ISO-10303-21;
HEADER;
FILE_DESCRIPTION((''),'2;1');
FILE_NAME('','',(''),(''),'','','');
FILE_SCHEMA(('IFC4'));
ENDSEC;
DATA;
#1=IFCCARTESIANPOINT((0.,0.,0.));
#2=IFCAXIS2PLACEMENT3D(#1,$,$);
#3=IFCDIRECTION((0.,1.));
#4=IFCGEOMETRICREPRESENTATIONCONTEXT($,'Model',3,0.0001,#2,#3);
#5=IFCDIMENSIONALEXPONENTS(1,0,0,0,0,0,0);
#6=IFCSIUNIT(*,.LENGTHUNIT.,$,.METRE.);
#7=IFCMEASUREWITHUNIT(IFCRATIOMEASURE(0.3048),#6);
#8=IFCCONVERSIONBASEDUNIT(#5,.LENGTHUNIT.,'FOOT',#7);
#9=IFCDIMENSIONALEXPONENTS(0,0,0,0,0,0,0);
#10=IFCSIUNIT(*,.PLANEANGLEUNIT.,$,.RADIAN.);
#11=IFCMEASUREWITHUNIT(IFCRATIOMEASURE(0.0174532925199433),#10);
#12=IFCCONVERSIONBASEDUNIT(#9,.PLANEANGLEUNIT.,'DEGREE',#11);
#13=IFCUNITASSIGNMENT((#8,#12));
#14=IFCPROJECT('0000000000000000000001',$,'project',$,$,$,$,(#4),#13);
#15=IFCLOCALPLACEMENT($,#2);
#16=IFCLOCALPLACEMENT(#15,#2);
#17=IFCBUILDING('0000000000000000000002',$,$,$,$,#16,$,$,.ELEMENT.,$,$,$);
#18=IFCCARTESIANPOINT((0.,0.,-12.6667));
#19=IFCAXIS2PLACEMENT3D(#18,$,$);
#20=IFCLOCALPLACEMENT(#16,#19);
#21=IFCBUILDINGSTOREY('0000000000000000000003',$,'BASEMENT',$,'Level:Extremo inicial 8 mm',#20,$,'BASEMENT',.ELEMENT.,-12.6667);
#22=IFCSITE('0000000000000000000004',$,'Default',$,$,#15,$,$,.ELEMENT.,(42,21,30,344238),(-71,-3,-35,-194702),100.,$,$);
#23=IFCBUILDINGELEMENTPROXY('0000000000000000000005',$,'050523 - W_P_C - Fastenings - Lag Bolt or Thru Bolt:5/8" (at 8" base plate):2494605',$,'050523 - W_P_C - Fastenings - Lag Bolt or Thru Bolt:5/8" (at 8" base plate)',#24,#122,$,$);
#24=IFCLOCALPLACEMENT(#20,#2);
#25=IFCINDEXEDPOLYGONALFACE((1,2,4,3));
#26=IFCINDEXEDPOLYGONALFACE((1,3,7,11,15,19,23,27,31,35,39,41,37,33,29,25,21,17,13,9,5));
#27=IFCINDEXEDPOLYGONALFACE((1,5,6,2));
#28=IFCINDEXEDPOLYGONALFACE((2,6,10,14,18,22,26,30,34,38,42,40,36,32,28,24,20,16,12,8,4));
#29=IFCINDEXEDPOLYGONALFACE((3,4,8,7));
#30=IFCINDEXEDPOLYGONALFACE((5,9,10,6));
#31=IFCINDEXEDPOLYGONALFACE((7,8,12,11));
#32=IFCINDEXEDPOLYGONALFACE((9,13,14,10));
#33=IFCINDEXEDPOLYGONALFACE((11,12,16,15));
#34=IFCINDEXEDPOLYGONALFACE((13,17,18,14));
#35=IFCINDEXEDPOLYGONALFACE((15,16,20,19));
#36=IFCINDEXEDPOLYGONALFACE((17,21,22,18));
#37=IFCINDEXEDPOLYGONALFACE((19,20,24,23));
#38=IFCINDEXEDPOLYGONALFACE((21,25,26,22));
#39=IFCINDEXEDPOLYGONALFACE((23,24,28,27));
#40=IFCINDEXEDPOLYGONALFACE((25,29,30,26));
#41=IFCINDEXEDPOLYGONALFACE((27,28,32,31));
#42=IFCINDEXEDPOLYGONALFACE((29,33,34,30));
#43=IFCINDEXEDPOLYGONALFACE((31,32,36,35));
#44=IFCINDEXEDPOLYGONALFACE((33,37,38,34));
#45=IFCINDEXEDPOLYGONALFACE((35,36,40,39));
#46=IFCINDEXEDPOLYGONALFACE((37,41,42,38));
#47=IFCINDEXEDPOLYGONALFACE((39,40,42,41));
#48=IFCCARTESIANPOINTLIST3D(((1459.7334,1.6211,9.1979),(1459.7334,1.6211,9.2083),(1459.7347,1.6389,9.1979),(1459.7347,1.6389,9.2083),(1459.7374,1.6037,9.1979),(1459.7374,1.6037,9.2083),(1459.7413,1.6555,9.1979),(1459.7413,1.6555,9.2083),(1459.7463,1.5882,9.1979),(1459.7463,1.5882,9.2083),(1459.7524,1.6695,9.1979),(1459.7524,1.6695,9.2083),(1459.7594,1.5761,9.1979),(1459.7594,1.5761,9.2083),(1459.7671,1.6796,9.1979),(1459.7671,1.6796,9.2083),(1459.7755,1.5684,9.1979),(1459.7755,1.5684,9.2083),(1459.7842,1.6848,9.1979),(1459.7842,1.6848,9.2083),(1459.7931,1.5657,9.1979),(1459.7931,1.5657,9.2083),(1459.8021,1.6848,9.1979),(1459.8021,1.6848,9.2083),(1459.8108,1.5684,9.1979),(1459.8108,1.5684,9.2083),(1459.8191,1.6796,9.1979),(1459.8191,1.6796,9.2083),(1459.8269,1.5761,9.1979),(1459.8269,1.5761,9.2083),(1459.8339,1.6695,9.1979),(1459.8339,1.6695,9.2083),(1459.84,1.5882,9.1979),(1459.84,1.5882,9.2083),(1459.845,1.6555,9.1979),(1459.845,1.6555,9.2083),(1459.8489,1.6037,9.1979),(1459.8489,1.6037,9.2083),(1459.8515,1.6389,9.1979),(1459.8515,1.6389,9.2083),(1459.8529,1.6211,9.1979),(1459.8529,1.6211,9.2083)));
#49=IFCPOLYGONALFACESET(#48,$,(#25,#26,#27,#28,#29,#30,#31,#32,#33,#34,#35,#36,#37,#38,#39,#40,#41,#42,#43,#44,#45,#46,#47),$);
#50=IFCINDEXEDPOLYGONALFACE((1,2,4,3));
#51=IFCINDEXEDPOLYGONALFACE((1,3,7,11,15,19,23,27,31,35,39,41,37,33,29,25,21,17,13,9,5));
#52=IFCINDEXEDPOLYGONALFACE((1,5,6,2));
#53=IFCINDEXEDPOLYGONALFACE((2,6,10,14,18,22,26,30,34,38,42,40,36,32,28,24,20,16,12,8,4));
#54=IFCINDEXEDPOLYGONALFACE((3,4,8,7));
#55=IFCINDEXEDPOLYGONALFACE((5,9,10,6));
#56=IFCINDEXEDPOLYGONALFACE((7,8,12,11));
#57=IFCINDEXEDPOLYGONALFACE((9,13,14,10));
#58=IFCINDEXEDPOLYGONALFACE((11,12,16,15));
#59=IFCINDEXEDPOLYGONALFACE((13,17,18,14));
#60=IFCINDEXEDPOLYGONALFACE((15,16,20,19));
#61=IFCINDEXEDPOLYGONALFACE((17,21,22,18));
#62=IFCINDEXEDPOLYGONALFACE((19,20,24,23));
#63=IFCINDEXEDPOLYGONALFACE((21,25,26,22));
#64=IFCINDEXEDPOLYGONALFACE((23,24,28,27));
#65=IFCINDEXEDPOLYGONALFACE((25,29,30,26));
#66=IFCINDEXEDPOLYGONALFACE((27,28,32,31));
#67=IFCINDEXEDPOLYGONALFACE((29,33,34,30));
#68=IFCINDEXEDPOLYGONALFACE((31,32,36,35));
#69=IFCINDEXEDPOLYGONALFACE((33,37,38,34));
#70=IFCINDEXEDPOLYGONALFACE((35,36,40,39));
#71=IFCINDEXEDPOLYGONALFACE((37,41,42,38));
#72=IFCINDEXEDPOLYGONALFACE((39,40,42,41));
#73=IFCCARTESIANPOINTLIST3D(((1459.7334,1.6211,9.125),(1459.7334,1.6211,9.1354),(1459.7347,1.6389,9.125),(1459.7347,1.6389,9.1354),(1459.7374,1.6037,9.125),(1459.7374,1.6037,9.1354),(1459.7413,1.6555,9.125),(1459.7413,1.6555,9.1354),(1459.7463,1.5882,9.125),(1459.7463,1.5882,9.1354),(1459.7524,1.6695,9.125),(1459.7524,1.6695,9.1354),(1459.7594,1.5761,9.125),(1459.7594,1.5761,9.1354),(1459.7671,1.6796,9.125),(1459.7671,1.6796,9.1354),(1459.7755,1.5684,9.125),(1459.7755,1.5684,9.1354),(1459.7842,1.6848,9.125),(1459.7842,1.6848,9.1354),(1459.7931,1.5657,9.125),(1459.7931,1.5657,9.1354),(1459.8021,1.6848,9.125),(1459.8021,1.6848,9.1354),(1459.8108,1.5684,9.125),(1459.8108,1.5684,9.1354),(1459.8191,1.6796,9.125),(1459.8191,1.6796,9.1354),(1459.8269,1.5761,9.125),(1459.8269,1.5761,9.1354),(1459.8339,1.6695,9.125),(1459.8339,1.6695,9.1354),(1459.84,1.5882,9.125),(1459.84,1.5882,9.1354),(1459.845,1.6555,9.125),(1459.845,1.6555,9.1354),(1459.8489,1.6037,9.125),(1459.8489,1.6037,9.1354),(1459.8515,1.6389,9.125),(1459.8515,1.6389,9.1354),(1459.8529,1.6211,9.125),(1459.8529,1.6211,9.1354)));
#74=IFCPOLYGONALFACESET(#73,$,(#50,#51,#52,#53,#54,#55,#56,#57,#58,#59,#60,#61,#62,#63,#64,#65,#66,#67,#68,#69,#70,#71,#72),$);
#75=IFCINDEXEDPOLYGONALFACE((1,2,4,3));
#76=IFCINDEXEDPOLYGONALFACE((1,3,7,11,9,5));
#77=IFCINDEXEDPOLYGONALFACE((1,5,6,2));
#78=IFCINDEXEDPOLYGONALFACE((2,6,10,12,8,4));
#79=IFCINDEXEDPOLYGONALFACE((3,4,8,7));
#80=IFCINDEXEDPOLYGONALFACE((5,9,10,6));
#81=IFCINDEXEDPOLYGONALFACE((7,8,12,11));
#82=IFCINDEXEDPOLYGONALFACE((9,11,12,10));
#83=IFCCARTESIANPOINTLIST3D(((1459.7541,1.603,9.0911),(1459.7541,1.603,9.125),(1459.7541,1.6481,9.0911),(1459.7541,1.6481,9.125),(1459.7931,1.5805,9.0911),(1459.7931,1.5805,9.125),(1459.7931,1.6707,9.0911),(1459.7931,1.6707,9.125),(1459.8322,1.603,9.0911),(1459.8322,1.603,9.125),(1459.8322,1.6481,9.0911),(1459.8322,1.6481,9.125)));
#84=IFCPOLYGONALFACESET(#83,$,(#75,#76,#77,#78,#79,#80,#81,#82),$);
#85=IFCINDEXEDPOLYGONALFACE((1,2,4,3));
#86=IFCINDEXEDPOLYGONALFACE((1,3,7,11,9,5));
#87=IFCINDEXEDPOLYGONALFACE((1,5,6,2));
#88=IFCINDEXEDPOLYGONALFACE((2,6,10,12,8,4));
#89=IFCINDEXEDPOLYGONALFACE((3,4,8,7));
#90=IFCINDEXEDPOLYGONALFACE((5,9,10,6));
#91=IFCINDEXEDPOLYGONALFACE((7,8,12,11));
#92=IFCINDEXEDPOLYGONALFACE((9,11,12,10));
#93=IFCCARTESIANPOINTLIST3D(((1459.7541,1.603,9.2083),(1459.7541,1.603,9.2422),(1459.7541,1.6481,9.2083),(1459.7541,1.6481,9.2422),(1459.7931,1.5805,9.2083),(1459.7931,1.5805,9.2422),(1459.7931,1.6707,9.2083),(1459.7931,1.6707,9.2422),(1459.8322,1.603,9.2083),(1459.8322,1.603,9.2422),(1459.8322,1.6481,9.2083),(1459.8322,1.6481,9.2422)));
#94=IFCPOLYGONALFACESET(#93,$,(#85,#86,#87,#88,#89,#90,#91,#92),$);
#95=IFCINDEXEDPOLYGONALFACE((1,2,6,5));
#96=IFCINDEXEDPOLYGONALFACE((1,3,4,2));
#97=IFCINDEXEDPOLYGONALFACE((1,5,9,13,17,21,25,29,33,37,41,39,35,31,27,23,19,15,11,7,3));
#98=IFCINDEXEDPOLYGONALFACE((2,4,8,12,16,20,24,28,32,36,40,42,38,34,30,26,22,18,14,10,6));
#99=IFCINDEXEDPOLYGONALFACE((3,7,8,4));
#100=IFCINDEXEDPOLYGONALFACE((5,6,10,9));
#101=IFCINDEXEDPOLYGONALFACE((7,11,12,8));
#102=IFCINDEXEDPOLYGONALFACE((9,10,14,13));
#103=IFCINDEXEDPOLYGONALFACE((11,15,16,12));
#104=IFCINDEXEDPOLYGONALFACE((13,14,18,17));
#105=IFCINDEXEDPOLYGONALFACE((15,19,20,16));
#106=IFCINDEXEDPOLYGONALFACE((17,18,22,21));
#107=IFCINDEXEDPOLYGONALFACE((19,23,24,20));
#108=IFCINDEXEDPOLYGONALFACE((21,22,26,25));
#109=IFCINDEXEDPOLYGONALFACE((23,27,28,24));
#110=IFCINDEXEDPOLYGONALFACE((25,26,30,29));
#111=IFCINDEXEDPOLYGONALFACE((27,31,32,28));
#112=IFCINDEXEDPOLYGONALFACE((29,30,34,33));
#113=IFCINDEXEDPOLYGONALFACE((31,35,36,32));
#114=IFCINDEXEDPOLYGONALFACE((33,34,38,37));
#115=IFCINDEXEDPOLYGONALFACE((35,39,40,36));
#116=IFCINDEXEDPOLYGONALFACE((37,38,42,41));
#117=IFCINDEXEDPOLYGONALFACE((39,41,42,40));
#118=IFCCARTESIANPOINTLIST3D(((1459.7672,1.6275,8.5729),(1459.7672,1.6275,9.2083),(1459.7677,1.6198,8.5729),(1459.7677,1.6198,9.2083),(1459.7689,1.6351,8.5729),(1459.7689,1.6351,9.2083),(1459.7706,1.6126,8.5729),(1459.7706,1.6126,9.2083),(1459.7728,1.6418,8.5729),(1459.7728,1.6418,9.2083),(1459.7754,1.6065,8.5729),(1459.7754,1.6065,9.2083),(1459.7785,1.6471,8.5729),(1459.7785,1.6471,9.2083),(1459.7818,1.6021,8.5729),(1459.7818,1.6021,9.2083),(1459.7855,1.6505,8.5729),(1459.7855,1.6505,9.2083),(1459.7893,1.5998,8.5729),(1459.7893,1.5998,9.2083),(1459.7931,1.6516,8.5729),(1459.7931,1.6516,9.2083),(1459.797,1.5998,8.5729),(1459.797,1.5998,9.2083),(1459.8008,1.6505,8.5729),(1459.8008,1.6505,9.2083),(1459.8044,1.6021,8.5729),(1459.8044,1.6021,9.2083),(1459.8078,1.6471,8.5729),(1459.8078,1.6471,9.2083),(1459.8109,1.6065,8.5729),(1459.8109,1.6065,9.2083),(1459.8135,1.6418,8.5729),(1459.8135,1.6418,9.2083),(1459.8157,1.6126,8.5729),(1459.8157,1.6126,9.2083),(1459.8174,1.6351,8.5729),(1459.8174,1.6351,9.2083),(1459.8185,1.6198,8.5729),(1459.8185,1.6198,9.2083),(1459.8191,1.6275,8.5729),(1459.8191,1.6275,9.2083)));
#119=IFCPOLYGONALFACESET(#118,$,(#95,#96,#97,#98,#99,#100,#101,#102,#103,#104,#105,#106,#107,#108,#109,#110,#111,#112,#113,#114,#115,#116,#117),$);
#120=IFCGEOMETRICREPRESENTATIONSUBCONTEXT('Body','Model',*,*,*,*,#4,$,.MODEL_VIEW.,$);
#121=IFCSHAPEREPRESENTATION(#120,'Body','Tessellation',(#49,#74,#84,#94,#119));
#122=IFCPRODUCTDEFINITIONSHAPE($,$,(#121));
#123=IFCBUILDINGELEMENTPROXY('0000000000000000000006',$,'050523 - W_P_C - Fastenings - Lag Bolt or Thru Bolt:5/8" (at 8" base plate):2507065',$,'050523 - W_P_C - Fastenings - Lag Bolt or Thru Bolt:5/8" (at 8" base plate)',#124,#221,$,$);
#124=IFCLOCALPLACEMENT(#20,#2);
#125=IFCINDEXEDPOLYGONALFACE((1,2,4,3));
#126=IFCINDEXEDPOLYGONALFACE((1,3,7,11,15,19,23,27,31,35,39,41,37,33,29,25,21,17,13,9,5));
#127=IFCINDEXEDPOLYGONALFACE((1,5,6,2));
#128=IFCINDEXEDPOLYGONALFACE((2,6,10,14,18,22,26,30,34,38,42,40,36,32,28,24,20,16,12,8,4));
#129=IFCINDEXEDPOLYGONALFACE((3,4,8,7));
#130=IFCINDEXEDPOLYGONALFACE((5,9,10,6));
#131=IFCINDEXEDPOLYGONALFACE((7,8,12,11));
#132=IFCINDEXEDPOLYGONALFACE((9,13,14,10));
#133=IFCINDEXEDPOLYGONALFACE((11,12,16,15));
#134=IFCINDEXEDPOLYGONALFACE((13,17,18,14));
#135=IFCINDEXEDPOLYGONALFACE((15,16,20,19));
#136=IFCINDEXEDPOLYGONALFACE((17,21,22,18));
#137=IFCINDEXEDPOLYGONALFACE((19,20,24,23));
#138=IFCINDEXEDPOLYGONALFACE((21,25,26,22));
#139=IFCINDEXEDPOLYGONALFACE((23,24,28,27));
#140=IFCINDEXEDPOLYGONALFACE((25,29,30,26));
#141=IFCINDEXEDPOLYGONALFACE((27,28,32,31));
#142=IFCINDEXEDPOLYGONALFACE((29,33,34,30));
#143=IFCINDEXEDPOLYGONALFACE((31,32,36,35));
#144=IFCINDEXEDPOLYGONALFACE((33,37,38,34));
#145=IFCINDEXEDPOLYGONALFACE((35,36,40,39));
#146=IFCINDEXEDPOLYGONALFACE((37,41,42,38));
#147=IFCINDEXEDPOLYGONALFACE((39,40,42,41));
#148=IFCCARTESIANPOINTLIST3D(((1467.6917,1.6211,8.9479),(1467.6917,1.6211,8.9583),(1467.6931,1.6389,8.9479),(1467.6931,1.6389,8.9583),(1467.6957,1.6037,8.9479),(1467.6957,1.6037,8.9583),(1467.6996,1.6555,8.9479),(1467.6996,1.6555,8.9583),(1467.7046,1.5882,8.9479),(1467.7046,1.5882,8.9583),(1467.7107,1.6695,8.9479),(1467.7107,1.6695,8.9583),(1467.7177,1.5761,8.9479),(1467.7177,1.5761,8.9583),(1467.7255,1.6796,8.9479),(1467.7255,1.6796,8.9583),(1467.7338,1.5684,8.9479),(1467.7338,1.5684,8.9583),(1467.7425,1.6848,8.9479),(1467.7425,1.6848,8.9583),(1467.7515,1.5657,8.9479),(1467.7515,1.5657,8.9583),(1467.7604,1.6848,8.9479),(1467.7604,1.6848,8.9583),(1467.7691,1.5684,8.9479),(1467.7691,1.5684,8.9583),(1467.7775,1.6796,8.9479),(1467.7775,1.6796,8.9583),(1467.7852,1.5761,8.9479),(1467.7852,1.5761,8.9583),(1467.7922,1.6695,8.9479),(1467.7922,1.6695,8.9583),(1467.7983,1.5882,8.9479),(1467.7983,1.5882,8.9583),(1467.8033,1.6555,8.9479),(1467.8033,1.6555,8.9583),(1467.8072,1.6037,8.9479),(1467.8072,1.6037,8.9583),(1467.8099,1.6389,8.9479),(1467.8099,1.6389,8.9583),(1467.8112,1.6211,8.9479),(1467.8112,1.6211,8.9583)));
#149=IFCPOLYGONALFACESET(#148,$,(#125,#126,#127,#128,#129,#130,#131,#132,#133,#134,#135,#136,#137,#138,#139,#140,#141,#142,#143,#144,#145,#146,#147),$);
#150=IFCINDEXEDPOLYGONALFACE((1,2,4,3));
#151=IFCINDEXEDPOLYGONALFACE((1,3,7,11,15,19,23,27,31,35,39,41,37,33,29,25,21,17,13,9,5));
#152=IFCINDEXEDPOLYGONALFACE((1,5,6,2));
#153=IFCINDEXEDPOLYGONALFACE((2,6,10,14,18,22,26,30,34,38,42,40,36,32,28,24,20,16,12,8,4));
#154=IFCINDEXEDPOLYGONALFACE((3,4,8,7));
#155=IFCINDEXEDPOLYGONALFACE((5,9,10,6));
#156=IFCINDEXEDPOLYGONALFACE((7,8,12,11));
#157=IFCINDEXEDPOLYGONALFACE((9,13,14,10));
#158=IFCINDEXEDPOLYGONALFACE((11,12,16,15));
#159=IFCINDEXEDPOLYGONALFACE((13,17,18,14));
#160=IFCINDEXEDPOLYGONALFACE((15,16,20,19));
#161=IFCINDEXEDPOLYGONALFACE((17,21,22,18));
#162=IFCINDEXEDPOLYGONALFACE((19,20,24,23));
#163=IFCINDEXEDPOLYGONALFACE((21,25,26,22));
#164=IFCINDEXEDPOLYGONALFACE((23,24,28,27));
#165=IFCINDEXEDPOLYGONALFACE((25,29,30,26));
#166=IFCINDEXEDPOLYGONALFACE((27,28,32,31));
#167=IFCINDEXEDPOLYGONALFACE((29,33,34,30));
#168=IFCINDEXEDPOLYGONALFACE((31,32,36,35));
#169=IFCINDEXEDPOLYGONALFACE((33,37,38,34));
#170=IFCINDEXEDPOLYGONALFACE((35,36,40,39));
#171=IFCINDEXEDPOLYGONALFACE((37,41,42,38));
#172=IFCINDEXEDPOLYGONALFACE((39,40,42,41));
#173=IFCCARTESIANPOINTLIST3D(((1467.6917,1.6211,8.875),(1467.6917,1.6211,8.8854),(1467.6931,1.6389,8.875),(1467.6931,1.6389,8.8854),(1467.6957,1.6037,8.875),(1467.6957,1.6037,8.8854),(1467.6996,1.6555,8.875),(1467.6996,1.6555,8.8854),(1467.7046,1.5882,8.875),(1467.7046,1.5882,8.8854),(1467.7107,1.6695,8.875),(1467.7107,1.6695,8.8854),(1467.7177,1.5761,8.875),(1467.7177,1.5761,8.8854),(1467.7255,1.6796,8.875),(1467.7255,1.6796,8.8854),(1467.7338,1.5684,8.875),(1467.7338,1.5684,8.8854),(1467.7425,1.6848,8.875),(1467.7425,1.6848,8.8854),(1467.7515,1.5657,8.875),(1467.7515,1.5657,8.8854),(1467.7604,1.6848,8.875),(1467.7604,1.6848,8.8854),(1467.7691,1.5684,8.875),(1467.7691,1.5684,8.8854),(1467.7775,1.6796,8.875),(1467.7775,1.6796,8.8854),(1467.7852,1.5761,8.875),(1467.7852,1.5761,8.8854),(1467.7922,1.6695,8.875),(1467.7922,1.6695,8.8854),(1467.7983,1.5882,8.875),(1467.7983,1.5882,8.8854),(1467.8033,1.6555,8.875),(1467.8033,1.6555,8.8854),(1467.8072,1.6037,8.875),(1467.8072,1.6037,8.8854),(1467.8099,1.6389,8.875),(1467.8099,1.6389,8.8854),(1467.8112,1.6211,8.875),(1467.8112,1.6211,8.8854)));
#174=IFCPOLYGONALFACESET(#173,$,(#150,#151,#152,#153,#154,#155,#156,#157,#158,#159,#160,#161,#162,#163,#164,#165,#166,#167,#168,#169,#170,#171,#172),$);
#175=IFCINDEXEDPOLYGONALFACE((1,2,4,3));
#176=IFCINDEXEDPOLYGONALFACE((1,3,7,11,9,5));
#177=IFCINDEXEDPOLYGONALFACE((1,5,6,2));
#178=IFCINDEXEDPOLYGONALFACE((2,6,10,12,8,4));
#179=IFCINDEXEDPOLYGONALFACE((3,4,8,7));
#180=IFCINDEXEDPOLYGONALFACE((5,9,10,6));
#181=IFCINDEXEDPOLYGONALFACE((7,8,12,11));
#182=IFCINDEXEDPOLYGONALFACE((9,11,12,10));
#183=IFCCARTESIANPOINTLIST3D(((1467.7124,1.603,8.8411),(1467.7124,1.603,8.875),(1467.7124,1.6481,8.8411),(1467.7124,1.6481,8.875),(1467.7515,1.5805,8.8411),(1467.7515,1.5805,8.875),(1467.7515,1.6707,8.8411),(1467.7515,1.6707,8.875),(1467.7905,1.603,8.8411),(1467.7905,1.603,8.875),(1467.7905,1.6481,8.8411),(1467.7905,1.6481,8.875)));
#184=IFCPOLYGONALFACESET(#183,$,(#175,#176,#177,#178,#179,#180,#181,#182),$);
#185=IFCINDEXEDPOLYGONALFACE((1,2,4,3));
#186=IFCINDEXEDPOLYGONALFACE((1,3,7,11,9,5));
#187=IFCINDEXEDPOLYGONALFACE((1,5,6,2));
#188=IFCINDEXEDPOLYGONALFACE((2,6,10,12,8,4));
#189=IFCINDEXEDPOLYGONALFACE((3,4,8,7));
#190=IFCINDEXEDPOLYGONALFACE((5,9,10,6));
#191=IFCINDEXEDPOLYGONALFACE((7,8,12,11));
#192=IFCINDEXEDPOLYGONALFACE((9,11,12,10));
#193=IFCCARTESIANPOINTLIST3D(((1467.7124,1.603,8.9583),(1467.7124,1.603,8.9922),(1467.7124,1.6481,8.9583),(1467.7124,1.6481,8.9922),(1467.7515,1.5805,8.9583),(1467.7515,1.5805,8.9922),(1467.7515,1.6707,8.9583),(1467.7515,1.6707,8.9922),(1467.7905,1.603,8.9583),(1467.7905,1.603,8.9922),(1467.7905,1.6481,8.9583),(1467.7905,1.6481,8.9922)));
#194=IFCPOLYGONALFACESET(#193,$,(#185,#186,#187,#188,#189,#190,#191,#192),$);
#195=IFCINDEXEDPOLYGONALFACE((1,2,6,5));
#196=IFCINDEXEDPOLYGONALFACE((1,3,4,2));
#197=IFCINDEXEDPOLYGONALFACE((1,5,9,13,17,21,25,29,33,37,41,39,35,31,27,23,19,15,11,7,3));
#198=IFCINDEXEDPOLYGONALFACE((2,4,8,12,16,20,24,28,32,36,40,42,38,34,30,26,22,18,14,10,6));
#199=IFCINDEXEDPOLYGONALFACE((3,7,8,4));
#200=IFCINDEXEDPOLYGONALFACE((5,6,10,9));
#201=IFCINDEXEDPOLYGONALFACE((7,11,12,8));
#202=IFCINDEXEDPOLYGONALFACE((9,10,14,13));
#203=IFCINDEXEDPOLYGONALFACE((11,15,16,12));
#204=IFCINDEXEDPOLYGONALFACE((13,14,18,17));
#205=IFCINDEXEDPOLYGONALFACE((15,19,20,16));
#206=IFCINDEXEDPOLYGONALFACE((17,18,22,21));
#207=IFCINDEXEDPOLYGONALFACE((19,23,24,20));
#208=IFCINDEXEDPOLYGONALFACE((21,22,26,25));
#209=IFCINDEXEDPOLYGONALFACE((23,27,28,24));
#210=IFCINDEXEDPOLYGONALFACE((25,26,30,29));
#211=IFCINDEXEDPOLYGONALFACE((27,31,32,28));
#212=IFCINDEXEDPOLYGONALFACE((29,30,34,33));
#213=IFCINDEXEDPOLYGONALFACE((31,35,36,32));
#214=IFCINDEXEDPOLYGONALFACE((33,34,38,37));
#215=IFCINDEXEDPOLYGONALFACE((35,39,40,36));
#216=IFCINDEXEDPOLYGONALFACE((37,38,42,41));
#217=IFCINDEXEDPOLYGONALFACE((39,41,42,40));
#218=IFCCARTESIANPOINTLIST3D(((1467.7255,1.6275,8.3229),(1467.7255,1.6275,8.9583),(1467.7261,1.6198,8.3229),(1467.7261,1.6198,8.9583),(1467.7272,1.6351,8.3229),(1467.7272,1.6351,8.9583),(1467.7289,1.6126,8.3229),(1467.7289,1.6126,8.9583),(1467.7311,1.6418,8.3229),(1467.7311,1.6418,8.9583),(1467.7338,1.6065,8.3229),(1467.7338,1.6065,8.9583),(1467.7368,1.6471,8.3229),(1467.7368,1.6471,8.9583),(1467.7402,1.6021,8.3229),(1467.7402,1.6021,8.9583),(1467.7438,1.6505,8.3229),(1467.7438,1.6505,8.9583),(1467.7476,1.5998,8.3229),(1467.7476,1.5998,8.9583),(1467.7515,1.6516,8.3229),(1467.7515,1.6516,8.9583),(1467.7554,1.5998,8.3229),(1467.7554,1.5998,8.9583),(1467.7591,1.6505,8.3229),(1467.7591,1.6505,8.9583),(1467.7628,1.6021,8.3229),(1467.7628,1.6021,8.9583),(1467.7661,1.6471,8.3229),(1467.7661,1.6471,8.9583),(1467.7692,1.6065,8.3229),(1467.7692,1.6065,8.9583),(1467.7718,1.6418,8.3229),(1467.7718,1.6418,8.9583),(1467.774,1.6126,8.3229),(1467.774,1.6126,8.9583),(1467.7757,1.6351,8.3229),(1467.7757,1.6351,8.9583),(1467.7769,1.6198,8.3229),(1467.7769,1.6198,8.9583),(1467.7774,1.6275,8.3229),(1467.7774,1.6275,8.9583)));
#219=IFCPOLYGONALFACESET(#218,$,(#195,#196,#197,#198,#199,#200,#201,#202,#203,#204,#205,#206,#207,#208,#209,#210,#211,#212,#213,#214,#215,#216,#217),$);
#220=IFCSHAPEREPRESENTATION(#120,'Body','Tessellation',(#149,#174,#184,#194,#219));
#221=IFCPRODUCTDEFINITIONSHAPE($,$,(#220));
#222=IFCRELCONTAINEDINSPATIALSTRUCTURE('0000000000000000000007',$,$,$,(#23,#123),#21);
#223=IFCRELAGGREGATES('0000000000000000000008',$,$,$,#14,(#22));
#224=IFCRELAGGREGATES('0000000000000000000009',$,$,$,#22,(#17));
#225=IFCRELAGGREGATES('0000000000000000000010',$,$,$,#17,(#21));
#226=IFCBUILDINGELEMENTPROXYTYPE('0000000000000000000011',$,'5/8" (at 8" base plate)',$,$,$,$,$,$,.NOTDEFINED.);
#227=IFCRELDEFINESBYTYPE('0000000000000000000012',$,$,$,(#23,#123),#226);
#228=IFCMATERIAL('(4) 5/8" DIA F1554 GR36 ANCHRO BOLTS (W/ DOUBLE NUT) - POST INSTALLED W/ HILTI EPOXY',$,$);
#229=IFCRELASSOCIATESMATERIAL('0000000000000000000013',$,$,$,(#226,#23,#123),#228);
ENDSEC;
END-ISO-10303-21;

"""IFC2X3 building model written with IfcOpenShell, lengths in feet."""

from ifc_helpers import new_model, entity, si_unit, converted_unit, direction, frame, frame_2d, origin, place, context, subcontext, project, spatial, polyline, circle, outline, extrude, source, transform, mapped, material, type_object, type_shapes, element, save


model = new_model("IFC2X3")

# Units and contexts
model_context = context("Model", 3, precision=0.0001, world=origin(), true_north=direction((0.0, 1.0)))
body_context = subcontext(model_context, "Body", "Model", "MODEL_VIEW")
ifc_project = project(units=[converted_unit("LENGTHUNIT", "FOOT", entity("IfcRatioMeasure", 0.3048), si_unit("LENGTHUNIT", "METRE"), dimensions=[1, 0, 0, 0, 0, 0, 0]), converted_unit("PLANEANGLEUNIT", "DEGREE", entity("IfcRatioMeasure", 0.0174532925199433), si_unit("PLANEANGLEUNIT", "RADIAN"), dimensions=[0, 0, 0, 0, 0, 0, 0])], contexts=[model_context])

# Site, building, storey
site_placement = place(None, origin())
site = spatial("IfcSite", under=ifc_project, at=site_placement, Name="Default", CompositionType="ELEMENT", RefLatitude=(42, 21, 30, 344238), RefLongitude=(-71, -3, -35, -194702), RefElevation=100.0)
building_placement = place(site_placement, origin())
building = spatial("IfcBuilding", under=site, at=building_placement, CompositionType="ELEMENT")
storey_placement = place(building_placement, frame((0.0, 0.0, -12.6667)))
storey = spatial("IfcBuildingStorey", under=building, at=storey_placement, Name="BASEMENT", ObjectType="Level:Extremo inicial 8 mm", LongName="BASEMENT", CompositionType="ELEMENT", Elevation=-12.6667)

# Building element proxies
ifc_material_1 = material(Name="(4) 5/8\" DIA F1554 GR36 ANCHRO BOLTS (W/ DOUBLE NUT) - POST INSTALLED W/ HILTI EPOXY")
building_element_proxy_type_1 = type_object("IfcBuildingElementProxyType", Name="5/8\" (at 8\" base plate)", PredefinedType="NOTDEFINED", material=ifc_material_1)
shared_shape_1 = source(origin(), body_context, "Body", "SweptSolid", [
    extrude(circle(Radius=0.0599, at=frame_2d((0.0, 0.0), x_axis=(1.0, 0.0))), frame((0.0, 0.0, 0.0), z_axis=(0.0, 0.0, 1.0), x_axis=(0.0, -1.0, 0.0)), (0.0, 0.0, 1.0), 0.0104),
    extrude(circle(Radius=0.0599, at=frame_2d((0.0, 0.0), x_axis=(1.0, 0.0))), frame((0.0, 0.0, -0.0729), z_axis=(0.0, 0.0, 1.0), x_axis=(0.0, -1.0, 0.0)), (0.0, 0.0, 1.0), 0.0104),
    extrude(outline(polyline([(-0.0226, -0.0391), (0.0226, -0.0391), (0.0451, 0.0), (0.0226, 0.0391), (-0.0226, 0.0391), (-0.0451, 0.0), (-0.0226, -0.0391)])), frame((0.0, 0.0, -0.1068), z_axis=(0.0, 0.0, 1.0), x_axis=(0.866025, -0.5, 0.0)), (0.0, 0.0, 1.0), 0.0339),
    extrude(outline(polyline([(-0.0226, -0.0391), (0.0226, -0.0391), (0.0451, 0.0), (0.0226, 0.0391), (-0.0226, 0.0391), (-0.0451, 0.0), (-0.0226, -0.0391)])), frame((0.0, 0.0, 0.0104), z_axis=(0.0, 0.0, 1.0), x_axis=(0.0, -1.0, 0.0)), (0.0, 0.0, 1.0), 0.0339),
    extrude(circle(Radius=0.026, at=frame_2d((0.0, 0.0), x_axis=(1.0, 0.0))), frame((0.0, 0.0, -0.625), z_axis=(0.0, 0.0, 1.0), x_axis=(0.0, 1.0, 0.0)), (0.0, 0.0, 1.0), 0.6354),
])
type_shapes(building_element_proxy_type_1, [shared_shape_1])
for number, where, name in (
    (1, (1459.7931, 1.6256, 9.1979), "050523 - W_P_C - Fastenings - Lag Bolt or Thru Bolt:5/8\" (at 8\" base plate):2494605"),
    (2, (1467.7515, 1.6256, 8.9479), "050523 - W_P_C - Fastenings - Lag Bolt or Thru Bolt:5/8\" (at 8\" base plate):2507065"),
):
    element("IfcBuildingElementProxy", number, at=place(storey_placement, frame(where)), inside=storey, type_object=building_element_proxy_type_1, material=ifc_material_1, Name=name, ObjectType="050523 - W_P_C - Fastenings - Lag Bolt or Thru Bolt:5/8\" (at 8\" base plate)", context=body_context, shape_type="MappedRepresentation", body=[
        mapped(shared_shape_1, transform((0.0, 0.0, 0.0), scale=1.0)),
    ])

save(model, "model.ifc")
